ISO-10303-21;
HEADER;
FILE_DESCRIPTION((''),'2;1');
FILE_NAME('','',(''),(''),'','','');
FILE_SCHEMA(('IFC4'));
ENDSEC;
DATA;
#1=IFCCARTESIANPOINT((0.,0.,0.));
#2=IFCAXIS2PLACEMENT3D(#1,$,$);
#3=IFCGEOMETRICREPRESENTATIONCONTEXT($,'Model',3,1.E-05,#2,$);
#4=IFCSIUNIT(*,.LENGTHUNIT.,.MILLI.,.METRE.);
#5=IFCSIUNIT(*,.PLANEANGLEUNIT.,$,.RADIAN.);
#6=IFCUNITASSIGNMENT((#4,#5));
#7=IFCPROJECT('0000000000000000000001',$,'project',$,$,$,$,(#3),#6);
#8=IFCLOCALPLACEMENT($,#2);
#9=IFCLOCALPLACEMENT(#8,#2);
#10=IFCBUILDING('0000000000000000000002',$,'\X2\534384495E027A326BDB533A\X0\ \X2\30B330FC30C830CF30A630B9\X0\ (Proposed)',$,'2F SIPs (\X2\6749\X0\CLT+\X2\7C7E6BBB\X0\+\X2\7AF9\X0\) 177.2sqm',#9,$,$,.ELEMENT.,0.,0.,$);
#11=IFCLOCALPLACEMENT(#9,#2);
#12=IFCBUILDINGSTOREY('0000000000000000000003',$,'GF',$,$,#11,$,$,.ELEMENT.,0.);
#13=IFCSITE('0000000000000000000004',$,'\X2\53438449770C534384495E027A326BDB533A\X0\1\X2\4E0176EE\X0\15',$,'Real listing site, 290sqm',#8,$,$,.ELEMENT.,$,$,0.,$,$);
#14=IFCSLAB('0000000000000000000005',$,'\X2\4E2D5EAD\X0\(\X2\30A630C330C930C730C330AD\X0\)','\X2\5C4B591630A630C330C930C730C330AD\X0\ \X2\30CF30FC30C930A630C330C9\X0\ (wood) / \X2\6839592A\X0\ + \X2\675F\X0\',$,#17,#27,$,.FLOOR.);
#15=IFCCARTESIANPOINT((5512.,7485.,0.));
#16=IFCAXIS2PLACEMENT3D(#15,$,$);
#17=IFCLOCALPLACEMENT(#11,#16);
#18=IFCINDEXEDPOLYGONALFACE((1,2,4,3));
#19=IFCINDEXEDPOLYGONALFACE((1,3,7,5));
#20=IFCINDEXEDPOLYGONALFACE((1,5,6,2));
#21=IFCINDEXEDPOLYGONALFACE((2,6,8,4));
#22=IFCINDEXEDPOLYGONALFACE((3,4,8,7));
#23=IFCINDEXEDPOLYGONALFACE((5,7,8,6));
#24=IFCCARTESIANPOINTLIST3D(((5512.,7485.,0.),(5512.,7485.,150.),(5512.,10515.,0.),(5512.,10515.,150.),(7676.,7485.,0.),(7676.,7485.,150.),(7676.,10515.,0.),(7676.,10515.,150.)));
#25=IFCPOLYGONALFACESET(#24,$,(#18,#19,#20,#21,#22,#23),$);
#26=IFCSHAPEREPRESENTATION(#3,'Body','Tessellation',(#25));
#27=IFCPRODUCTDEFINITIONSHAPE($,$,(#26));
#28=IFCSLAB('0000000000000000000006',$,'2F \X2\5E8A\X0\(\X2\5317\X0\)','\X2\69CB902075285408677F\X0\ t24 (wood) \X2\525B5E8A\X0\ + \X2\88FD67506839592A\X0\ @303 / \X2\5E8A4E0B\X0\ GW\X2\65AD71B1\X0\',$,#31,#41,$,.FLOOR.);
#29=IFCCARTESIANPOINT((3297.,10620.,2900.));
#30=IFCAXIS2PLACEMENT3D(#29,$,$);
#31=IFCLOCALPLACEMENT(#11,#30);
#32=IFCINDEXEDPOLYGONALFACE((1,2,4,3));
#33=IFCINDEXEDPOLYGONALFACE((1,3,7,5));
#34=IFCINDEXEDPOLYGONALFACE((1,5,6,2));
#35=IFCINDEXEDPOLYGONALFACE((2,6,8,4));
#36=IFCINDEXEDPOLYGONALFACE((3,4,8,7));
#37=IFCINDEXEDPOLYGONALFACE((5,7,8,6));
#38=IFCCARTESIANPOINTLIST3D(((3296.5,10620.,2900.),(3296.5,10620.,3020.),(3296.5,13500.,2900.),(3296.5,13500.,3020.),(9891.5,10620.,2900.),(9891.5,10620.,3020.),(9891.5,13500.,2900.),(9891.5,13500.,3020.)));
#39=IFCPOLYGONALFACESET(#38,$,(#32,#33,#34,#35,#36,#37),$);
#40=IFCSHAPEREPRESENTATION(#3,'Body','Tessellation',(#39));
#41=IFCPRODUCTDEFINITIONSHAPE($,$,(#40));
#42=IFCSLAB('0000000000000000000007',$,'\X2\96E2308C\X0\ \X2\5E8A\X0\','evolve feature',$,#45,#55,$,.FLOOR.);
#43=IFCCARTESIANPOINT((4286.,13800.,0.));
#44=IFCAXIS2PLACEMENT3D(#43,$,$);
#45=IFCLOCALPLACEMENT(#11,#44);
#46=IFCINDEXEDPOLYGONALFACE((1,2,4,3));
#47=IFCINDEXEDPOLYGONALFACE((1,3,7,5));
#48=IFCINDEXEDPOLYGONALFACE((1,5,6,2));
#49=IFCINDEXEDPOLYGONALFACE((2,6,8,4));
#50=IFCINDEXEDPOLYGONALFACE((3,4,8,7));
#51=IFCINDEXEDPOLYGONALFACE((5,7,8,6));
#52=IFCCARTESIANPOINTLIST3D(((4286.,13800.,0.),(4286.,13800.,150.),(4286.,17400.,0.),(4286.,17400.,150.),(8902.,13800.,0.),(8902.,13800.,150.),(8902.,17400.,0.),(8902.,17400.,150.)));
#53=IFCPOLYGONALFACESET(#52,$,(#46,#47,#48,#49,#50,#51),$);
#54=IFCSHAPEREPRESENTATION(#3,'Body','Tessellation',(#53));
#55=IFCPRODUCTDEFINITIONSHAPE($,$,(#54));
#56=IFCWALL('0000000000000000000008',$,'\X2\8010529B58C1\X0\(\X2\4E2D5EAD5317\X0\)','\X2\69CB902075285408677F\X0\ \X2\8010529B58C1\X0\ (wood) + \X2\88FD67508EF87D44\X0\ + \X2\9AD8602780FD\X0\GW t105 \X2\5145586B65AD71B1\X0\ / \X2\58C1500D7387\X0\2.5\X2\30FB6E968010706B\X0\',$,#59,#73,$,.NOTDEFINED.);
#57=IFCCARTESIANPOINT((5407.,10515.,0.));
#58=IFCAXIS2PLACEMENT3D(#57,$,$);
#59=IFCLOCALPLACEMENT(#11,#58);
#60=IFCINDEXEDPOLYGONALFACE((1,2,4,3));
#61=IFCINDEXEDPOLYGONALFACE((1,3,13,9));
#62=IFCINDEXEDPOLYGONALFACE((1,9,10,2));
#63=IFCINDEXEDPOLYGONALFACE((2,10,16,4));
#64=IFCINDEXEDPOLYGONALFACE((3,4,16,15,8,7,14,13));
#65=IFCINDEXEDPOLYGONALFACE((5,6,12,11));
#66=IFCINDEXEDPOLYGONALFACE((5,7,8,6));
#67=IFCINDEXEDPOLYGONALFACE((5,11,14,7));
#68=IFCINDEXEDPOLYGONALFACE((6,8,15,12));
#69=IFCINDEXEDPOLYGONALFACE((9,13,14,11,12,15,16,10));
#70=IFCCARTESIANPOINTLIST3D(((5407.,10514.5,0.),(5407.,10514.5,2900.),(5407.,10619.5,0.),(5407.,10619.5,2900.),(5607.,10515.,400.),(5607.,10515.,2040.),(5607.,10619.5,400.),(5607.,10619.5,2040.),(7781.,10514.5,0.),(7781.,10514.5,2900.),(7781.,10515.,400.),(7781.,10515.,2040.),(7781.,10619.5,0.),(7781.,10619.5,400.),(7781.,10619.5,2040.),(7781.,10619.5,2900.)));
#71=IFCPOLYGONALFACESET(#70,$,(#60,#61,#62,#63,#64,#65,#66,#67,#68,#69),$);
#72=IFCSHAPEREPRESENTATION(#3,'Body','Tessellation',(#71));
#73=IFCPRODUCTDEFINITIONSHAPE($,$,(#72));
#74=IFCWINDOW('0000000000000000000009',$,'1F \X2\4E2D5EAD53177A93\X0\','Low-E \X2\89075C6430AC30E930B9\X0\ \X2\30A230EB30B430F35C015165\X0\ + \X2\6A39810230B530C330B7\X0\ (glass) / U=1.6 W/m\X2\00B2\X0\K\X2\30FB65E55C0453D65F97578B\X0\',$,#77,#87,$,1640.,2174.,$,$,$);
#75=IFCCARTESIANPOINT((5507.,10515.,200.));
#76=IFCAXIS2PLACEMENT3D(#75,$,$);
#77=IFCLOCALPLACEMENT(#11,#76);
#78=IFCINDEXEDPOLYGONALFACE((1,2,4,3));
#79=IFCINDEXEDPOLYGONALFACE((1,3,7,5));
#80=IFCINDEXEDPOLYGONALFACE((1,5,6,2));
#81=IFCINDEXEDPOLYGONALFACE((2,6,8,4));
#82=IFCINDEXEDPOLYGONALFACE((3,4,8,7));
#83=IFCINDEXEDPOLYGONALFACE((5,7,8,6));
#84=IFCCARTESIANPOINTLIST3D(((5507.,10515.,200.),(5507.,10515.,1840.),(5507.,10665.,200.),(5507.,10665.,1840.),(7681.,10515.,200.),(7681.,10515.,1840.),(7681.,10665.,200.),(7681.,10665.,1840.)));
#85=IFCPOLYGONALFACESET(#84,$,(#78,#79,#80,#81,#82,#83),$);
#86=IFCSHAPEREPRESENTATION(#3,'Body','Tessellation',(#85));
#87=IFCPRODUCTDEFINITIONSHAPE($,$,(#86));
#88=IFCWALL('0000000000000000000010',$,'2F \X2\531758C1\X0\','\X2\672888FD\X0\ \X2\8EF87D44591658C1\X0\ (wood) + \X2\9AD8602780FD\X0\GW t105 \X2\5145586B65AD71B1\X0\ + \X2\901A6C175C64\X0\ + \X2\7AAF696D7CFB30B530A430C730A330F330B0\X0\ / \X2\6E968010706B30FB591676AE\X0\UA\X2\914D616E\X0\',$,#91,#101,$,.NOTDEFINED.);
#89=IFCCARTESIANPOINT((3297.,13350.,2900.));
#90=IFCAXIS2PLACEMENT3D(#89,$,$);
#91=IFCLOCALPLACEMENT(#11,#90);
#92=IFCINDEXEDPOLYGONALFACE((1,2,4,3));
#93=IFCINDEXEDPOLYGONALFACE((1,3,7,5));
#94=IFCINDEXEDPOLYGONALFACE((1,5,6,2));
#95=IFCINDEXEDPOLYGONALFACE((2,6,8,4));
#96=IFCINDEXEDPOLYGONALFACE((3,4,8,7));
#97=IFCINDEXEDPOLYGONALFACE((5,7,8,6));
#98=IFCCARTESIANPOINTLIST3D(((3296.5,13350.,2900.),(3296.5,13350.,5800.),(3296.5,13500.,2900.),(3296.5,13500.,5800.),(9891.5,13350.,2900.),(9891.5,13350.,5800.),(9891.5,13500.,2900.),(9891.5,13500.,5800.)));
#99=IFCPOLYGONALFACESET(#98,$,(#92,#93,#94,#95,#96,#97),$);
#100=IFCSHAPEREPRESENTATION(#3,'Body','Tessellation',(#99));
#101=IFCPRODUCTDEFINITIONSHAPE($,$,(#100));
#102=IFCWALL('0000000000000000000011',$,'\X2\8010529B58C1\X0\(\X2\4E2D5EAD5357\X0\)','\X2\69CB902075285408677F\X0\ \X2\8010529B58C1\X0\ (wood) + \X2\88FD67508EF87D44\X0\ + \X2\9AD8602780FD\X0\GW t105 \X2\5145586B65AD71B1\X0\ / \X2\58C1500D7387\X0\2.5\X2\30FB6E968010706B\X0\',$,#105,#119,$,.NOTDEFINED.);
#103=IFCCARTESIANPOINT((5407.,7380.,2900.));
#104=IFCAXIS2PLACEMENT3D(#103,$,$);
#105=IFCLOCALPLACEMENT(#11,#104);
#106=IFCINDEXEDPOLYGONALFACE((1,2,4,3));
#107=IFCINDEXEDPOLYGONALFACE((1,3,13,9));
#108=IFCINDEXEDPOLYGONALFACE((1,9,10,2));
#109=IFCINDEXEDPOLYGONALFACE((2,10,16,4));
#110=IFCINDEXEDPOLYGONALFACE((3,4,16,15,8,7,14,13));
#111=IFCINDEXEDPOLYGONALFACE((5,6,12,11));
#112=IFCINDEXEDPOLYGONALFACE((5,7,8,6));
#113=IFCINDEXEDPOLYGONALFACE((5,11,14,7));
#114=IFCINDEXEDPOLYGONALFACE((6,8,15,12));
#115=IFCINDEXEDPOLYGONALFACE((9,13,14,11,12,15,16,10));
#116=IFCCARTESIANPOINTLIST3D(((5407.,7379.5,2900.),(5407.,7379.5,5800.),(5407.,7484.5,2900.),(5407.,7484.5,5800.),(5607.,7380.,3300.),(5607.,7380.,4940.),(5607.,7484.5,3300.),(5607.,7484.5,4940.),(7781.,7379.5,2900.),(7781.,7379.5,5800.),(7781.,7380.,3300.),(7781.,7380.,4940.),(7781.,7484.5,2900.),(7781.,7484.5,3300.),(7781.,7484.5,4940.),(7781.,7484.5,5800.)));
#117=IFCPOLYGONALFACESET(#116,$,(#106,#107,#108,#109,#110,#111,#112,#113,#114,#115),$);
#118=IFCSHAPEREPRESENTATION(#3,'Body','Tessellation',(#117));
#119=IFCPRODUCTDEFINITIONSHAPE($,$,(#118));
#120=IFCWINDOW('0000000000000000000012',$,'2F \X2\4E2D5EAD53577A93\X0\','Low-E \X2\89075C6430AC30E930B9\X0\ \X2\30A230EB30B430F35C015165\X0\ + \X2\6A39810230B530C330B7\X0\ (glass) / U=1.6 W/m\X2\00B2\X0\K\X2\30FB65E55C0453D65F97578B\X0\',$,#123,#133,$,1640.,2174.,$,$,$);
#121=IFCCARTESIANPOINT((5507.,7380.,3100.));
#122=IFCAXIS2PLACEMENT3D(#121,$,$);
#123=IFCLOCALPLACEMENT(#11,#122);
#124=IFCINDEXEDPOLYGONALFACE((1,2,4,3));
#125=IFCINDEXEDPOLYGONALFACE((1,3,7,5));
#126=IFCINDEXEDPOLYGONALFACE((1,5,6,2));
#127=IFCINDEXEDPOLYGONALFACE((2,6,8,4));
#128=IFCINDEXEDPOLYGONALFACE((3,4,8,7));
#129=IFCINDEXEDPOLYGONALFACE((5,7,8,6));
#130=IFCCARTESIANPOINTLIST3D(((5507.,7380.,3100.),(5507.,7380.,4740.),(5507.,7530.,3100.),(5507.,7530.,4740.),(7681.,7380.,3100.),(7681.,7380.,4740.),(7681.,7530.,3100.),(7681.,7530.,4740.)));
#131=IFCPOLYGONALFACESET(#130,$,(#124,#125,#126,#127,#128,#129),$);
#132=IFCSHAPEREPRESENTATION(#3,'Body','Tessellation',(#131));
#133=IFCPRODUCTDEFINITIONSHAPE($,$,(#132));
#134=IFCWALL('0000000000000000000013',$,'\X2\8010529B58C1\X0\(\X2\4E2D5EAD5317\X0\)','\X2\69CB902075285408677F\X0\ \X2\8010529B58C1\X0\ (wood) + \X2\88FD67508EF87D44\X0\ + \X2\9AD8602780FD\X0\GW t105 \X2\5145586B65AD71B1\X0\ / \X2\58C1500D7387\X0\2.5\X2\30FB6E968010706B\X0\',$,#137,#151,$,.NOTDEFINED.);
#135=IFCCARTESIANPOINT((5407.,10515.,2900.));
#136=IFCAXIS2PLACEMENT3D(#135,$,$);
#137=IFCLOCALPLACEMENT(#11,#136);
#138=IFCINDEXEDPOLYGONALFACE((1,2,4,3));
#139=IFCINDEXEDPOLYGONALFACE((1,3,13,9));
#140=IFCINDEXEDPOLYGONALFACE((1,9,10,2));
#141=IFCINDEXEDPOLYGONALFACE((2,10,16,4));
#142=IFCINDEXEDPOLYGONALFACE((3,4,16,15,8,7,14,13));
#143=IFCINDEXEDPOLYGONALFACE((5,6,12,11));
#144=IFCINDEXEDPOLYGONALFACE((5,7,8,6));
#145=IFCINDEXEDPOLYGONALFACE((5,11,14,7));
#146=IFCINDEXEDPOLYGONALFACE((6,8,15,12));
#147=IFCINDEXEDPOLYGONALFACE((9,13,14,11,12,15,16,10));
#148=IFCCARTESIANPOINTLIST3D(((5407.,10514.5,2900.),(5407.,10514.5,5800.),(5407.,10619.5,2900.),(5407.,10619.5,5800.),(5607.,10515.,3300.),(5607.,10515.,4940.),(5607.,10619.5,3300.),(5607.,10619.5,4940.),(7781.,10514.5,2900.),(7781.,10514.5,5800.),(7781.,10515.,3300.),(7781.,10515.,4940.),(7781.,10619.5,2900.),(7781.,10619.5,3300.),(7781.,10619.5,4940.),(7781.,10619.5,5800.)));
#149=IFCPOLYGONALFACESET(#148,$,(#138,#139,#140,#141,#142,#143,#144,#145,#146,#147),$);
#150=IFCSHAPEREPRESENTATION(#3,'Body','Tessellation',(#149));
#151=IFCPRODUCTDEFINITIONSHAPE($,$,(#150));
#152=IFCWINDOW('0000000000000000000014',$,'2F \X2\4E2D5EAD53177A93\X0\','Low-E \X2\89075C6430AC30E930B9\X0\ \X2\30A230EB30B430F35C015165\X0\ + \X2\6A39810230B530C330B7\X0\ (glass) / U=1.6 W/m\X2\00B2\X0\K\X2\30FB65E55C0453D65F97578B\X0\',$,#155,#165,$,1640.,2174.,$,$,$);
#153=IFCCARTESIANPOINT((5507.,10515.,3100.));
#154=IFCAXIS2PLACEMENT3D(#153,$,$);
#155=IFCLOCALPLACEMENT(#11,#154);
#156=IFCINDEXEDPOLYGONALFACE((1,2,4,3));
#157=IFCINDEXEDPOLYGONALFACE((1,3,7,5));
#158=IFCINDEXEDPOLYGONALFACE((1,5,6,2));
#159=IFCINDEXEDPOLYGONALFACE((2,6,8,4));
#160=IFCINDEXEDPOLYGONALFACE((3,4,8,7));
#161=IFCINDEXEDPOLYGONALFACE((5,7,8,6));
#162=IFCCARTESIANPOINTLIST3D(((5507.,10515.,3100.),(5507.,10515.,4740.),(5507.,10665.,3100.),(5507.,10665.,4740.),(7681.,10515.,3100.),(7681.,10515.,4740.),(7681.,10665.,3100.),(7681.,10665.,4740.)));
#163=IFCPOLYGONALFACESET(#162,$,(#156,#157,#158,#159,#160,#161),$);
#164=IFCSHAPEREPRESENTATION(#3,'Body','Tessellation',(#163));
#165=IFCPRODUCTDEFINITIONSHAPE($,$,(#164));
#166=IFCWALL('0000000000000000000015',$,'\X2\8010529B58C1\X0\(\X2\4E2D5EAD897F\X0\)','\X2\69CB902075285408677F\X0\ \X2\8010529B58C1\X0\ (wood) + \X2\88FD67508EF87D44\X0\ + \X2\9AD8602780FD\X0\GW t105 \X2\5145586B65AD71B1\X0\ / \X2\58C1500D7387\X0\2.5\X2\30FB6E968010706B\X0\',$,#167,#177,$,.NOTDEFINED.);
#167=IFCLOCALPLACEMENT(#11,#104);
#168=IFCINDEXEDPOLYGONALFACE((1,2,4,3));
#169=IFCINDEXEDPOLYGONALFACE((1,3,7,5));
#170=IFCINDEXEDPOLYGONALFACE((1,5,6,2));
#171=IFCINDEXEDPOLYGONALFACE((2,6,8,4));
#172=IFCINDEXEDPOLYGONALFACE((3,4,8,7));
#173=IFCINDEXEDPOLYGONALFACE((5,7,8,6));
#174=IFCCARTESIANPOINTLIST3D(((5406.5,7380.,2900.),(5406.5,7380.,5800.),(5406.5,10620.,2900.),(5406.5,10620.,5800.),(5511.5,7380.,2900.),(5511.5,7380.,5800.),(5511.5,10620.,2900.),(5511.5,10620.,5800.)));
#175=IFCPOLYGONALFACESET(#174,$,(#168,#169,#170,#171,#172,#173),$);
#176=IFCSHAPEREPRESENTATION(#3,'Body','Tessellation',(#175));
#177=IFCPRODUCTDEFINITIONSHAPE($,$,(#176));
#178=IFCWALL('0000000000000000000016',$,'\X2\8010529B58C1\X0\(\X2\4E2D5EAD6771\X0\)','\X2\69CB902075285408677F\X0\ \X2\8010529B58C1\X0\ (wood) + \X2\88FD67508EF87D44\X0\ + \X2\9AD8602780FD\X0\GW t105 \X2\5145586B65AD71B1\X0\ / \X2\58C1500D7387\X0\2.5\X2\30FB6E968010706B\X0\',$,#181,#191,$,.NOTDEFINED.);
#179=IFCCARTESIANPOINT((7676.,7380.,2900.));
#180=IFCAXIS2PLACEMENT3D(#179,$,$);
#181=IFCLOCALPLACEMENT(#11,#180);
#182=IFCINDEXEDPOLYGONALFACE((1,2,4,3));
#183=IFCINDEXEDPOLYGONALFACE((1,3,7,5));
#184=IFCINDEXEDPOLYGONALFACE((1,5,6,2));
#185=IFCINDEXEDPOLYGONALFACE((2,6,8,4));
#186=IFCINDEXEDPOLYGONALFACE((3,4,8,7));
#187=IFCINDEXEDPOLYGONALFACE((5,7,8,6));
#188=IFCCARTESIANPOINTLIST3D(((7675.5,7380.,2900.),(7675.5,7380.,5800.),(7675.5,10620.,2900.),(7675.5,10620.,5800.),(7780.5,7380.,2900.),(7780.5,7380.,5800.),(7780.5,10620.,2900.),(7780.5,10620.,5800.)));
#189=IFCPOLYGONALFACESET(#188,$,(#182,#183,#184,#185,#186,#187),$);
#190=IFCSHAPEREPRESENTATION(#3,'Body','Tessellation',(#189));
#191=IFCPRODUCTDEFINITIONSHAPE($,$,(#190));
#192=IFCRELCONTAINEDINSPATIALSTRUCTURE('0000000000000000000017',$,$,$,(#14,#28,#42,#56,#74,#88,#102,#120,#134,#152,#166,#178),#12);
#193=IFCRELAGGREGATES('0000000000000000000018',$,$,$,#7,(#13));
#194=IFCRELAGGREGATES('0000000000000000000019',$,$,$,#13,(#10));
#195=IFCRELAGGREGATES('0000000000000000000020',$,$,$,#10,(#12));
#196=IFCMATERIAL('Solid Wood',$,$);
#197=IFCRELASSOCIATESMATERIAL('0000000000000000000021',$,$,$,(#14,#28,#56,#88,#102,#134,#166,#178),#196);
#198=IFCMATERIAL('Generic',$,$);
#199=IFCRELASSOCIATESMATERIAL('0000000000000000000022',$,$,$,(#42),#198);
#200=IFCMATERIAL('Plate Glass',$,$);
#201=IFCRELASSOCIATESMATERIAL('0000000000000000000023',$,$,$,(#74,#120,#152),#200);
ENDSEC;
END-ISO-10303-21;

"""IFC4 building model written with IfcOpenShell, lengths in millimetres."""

from ifc_helpers import new_model, si_unit, frame, frame_2d, origin, place, context, project, spatial, rectangle, extrude, material, element, fill, save


model = new_model("IFC4")

# Units and contexts
model_context = context("Model", 3, precision=1e-05, world=origin())
ifc_project = project(units=[si_unit("LENGTHUNIT", "METRE", prefix="MILLI"), si_unit("PLANEANGLEUNIT", "RADIAN")], contexts=[model_context])

# Site, building, storey
site_placement = place(None, origin())
site = spatial("IfcSite", under=ifc_project, at=site_placement, Name="千葉県千葉市稲毛区1丁目15", ObjectType="Real listing site, 290sqm", CompositionType="ELEMENT", RefElevation=0.0)
building_placement = place(site_placement, origin())
building = spatial("IfcBuilding", under=site, at=building_placement, Name="千葉市稲毛区 コートハウス (Proposed)", ObjectType="2F SIPs (杉CLT+籾殻+竹) 177.2sqm", CompositionType="ELEMENT", ElevationOfRefHeight=0.0, ElevationOfTerrain=0.0)
storey_placement = place(building_placement, origin())
storey = spatial("IfcBuildingStorey", under=building, at=storey_placement, Name="GF", CompositionType="ELEMENT", Elevation=0.0)

# Slabs
ifc_material_1 = material(Name="Solid Wood")
slab_1_placement = place(storey_placement, frame((5512.0, 7485.0, 0.0)))
element("IfcSlab", 1, at=slab_1_placement, inside=storey, material=ifc_material_1, Name="中庭(ウッドデッキ)", Description="屋外ウッドデッキ ハードウッド (wood) / 根太 + 束", PredefinedType="FLOOR", context=model_context, shape_type="SweptSolid", body=[
    extrude(rectangle(XDim=2164.0, YDim=3030.0, at=frame_2d((1082.0, 1515.0))), frame((5512.0, 7485.0, 0.0)), (0.0, 0.0, 1.0), 150.0),
])
slab_2_placement = place(storey_placement, frame((3297.0, 10620.0, 2900.0)))
element("IfcSlab", 2, at=slab_2_placement, inside=storey, material=ifc_material_1, Name="2F 床(北)", Description="構造用合板 t24 (wood) 剛床 + 製材根太 @303 / 床下 GW断熱", PredefinedType="FLOOR", context=model_context, shape_type="SweptSolid", body=[
    extrude(rectangle(XDim=6595.0, YDim=2880.0, at=frame_2d((3297.0, 1440.0))), frame((3297.0, 10620.0, 2900.0)), (0.0, 0.0, 1.0), 120.0),
])
ifc_material_2 = material(Name="Generic")
slab_3_placement = place(storey_placement, frame((4286.0, 13800.0, 0.0)))
element("IfcSlab", 3, at=slab_3_placement, inside=storey, material=ifc_material_2, Name="離れ 床", Description="evolve feature", PredefinedType="FLOOR", context=model_context, shape_type="SweptSolid", body=[
    extrude(rectangle(XDim=4616.0, YDim=3600.0, at=frame_2d((2308.0, 1800.0))), frame((4286.0, 13800.0, 0.0)), (0.0, 0.0, 1.0), 150.0),
])

# Wall, opening, window
wall_1_placement = place(storey_placement, frame((5407.0, 10515.0, 0.0)))
wall_1 = element("IfcWall", 4, at=wall_1_placement, inside=storey, material=ifc_material_1, Name="耐力壁(中庭北)", Description="構造用合板 耐力壁 (wood) + 製材軸組 + 高性能GW t105 充填断熱 / 壁倍率2.5・準耐火", PredefinedType="NOTDEFINED", context=model_context, shape_type="SweptSolid", body=[
    extrude(rectangle(XDim=2374.0, YDim=105.0, at=frame_2d((1187.0, 52.0))), frame((5407.0, 10515.0, 0.0)), (0.0, 0.0, 1.0), 2900.0),
])
opening_1_placement = place(storey_placement, frame((5507.0, 10515.0, 200.0)))
opening_1 = element("IfcOpeningElement", 5, at=opening_1_placement, cuts=wall_1, PredefinedType="NOTDEFINED", context=model_context, shape_type="SweptSolid", body=[
    extrude(rectangle(XDim=2174.0, YDim=150.0, at=frame_2d((1087.0, 75.0))), frame((5507.0, 10515.0, 200.0)), (0.0, 0.0, 1.0), 1640.0),
])
ifc_material_3 = material(Name="Plate Glass")
window_1_placement = place(storey_placement, frame((5507.0, 10515.0, 200.0)))
window_1 = element("IfcWindow", 6, at=window_1_placement, inside=storey, material=ifc_material_3, Name="1F 中庭北窓", Description="Low-E 複層ガラス アルゴン封入 + 樹脂サッシ (glass) / U=1.6 W/m²K・日射取得型", OverallHeight=1640.0, OverallWidth=2174.0, context=model_context, shape_type="SweptSolid", body=[
    extrude(rectangle(XDim=2174.0, YDim=150.0, at=frame_2d((1087.0, 75.0))), frame((5507.0, 10515.0, 200.0)), (0.0, 0.0, 1.0), 1640.0),
])
fill(opening_1, window_1)

# Wall
wall_2_placement = place(storey_placement, frame((3297.0, 13350.0, 2900.0)))
element("IfcWall", 7, at=wall_2_placement, inside=storey, material=ifc_material_1, Name="2F 北壁", Description="木製 軸組外壁 (wood) + 高性能GW t105 充填断熱 + 通気層 + 窯業系サイディング / 準耐火・外皮UA配慮", PredefinedType="NOTDEFINED", context=model_context, shape_type="SweptSolid", body=[
    extrude(rectangle(XDim=6595.0, YDim=150.0, at=frame_2d((3297.0, 75.0))), frame((3297.0, 13350.0, 2900.0)), (0.0, 0.0, 1.0), 2900.0),
])

# Walls, openings, windows
wall_3_placement = place(storey_placement, frame((5407.0, 7380.0, 2900.0)))
wall_3 = element("IfcWall", 8, at=wall_3_placement, inside=storey, material=ifc_material_1, Name="耐力壁(中庭南)", Description="構造用合板 耐力壁 (wood) + 製材軸組 + 高性能GW t105 充填断熱 / 壁倍率2.5・準耐火", PredefinedType="NOTDEFINED", context=model_context, shape_type="SweptSolid", body=[
    extrude(rectangle(XDim=2374.0, YDim=105.0, at=frame_2d((1187.0, 52.0))), frame((5407.0, 7380.0, 2900.0)), (0.0, 0.0, 1.0), 2900.0),
])
opening_2_placement = place(storey_placement, frame((5507.0, 7380.0, 3100.0)))
opening_2 = element("IfcOpeningElement", 9, at=opening_2_placement, cuts=wall_3, PredefinedType="NOTDEFINED", context=model_context, shape_type="SweptSolid", body=[
    extrude(rectangle(XDim=2174.0, YDim=150.0, at=frame_2d((1087.0, 75.0))), frame((5507.0, 7380.0, 3100.0)), (0.0, 0.0, 1.0), 1640.0),
])
window_2_placement = place(storey_placement, frame((5507.0, 7380.0, 3100.0)))
window_2 = element("IfcWindow", 10, at=window_2_placement, inside=storey, material=ifc_material_3, Name="2F 中庭南窓", Description="Low-E 複層ガラス アルゴン封入 + 樹脂サッシ (glass) / U=1.6 W/m²K・日射取得型", OverallHeight=1640.0, OverallWidth=2174.0, context=model_context, shape_type="SweptSolid", body=[
    extrude(rectangle(XDim=2174.0, YDim=150.0, at=frame_2d((1087.0, 75.0))), frame((5507.0, 7380.0, 3100.0)), (0.0, 0.0, 1.0), 1640.0),
])
fill(opening_2, window_2)
wall_4_placement = place(storey_placement, frame((5407.0, 10515.0, 2900.0)))
wall_4 = element("IfcWall", 11, at=wall_4_placement, inside=storey, material=ifc_material_1, Name="耐力壁(中庭北)", Description="構造用合板 耐力壁 (wood) + 製材軸組 + 高性能GW t105 充填断熱 / 壁倍率2.5・準耐火", PredefinedType="NOTDEFINED", context=model_context, shape_type="SweptSolid", body=[
    extrude(rectangle(XDim=2374.0, YDim=105.0, at=frame_2d((1187.0, 52.0))), frame((5407.0, 10515.0, 2900.0)), (0.0, 0.0, 1.0), 2900.0),
])
opening_3_placement = place(storey_placement, frame((5507.0, 10515.0, 3100.0)))
opening_3 = element("IfcOpeningElement", 12, at=opening_3_placement, cuts=wall_4, PredefinedType="NOTDEFINED", context=model_context, shape_type="SweptSolid", body=[
    extrude(rectangle(XDim=2174.0, YDim=150.0, at=frame_2d((1087.0, 75.0))), frame((5507.0, 10515.0, 3100.0)), (0.0, 0.0, 1.0), 1640.0),
])
window_3_placement = place(storey_placement, frame((5507.0, 10515.0, 3100.0)))
window_3 = element("IfcWindow", 13, at=window_3_placement, inside=storey, material=ifc_material_3, Name="2F 中庭北窓", Description="Low-E 複層ガラス アルゴン封入 + 樹脂サッシ (glass) / U=1.6 W/m²K・日射取得型", OverallHeight=1640.0, OverallWidth=2174.0, context=model_context, shape_type="SweptSolid", body=[
    extrude(rectangle(XDim=2174.0, YDim=150.0, at=frame_2d((1087.0, 75.0))), frame((5507.0, 10515.0, 3100.0)), (0.0, 0.0, 1.0), 1640.0),
])
fill(opening_3, window_3)

# Walls
wall_5_placement = place(storey_placement, frame((5407.0, 7380.0, 2900.0)))
element("IfcWall", 14, at=wall_5_placement, inside=storey, material=ifc_material_1, Name="耐力壁(中庭西)", Description="構造用合板 耐力壁 (wood) + 製材軸組 + 高性能GW t105 充填断熱 / 壁倍率2.5・準耐火", PredefinedType="NOTDEFINED", context=model_context, shape_type="SweptSolid", body=[
    extrude(rectangle(XDim=105.0, YDim=3240.0, at=frame_2d((52.0, 1620.0))), frame((5407.0, 7380.0, 2900.0)), (0.0, 0.0, 1.0), 2900.0),
])
wall_6_placement = place(storey_placement, frame((7676.0, 7380.0, 2900.0)))
element("IfcWall", 15, at=wall_6_placement, inside=storey, material=ifc_material_1, Name="耐力壁(中庭東)", Description="構造用合板 耐力壁 (wood) + 製材軸組 + 高性能GW t105 充填断熱 / 壁倍率2.5・準耐火", PredefinedType="NOTDEFINED", context=model_context, shape_type="SweptSolid", body=[
    extrude(rectangle(XDim=105.0, YDim=3240.0, at=frame_2d((52.0, 1620.0))), frame((7676.0, 7380.0, 2900.0)), (0.0, 0.0, 1.0), 2900.0),
])

save(model, "model.ifc")
